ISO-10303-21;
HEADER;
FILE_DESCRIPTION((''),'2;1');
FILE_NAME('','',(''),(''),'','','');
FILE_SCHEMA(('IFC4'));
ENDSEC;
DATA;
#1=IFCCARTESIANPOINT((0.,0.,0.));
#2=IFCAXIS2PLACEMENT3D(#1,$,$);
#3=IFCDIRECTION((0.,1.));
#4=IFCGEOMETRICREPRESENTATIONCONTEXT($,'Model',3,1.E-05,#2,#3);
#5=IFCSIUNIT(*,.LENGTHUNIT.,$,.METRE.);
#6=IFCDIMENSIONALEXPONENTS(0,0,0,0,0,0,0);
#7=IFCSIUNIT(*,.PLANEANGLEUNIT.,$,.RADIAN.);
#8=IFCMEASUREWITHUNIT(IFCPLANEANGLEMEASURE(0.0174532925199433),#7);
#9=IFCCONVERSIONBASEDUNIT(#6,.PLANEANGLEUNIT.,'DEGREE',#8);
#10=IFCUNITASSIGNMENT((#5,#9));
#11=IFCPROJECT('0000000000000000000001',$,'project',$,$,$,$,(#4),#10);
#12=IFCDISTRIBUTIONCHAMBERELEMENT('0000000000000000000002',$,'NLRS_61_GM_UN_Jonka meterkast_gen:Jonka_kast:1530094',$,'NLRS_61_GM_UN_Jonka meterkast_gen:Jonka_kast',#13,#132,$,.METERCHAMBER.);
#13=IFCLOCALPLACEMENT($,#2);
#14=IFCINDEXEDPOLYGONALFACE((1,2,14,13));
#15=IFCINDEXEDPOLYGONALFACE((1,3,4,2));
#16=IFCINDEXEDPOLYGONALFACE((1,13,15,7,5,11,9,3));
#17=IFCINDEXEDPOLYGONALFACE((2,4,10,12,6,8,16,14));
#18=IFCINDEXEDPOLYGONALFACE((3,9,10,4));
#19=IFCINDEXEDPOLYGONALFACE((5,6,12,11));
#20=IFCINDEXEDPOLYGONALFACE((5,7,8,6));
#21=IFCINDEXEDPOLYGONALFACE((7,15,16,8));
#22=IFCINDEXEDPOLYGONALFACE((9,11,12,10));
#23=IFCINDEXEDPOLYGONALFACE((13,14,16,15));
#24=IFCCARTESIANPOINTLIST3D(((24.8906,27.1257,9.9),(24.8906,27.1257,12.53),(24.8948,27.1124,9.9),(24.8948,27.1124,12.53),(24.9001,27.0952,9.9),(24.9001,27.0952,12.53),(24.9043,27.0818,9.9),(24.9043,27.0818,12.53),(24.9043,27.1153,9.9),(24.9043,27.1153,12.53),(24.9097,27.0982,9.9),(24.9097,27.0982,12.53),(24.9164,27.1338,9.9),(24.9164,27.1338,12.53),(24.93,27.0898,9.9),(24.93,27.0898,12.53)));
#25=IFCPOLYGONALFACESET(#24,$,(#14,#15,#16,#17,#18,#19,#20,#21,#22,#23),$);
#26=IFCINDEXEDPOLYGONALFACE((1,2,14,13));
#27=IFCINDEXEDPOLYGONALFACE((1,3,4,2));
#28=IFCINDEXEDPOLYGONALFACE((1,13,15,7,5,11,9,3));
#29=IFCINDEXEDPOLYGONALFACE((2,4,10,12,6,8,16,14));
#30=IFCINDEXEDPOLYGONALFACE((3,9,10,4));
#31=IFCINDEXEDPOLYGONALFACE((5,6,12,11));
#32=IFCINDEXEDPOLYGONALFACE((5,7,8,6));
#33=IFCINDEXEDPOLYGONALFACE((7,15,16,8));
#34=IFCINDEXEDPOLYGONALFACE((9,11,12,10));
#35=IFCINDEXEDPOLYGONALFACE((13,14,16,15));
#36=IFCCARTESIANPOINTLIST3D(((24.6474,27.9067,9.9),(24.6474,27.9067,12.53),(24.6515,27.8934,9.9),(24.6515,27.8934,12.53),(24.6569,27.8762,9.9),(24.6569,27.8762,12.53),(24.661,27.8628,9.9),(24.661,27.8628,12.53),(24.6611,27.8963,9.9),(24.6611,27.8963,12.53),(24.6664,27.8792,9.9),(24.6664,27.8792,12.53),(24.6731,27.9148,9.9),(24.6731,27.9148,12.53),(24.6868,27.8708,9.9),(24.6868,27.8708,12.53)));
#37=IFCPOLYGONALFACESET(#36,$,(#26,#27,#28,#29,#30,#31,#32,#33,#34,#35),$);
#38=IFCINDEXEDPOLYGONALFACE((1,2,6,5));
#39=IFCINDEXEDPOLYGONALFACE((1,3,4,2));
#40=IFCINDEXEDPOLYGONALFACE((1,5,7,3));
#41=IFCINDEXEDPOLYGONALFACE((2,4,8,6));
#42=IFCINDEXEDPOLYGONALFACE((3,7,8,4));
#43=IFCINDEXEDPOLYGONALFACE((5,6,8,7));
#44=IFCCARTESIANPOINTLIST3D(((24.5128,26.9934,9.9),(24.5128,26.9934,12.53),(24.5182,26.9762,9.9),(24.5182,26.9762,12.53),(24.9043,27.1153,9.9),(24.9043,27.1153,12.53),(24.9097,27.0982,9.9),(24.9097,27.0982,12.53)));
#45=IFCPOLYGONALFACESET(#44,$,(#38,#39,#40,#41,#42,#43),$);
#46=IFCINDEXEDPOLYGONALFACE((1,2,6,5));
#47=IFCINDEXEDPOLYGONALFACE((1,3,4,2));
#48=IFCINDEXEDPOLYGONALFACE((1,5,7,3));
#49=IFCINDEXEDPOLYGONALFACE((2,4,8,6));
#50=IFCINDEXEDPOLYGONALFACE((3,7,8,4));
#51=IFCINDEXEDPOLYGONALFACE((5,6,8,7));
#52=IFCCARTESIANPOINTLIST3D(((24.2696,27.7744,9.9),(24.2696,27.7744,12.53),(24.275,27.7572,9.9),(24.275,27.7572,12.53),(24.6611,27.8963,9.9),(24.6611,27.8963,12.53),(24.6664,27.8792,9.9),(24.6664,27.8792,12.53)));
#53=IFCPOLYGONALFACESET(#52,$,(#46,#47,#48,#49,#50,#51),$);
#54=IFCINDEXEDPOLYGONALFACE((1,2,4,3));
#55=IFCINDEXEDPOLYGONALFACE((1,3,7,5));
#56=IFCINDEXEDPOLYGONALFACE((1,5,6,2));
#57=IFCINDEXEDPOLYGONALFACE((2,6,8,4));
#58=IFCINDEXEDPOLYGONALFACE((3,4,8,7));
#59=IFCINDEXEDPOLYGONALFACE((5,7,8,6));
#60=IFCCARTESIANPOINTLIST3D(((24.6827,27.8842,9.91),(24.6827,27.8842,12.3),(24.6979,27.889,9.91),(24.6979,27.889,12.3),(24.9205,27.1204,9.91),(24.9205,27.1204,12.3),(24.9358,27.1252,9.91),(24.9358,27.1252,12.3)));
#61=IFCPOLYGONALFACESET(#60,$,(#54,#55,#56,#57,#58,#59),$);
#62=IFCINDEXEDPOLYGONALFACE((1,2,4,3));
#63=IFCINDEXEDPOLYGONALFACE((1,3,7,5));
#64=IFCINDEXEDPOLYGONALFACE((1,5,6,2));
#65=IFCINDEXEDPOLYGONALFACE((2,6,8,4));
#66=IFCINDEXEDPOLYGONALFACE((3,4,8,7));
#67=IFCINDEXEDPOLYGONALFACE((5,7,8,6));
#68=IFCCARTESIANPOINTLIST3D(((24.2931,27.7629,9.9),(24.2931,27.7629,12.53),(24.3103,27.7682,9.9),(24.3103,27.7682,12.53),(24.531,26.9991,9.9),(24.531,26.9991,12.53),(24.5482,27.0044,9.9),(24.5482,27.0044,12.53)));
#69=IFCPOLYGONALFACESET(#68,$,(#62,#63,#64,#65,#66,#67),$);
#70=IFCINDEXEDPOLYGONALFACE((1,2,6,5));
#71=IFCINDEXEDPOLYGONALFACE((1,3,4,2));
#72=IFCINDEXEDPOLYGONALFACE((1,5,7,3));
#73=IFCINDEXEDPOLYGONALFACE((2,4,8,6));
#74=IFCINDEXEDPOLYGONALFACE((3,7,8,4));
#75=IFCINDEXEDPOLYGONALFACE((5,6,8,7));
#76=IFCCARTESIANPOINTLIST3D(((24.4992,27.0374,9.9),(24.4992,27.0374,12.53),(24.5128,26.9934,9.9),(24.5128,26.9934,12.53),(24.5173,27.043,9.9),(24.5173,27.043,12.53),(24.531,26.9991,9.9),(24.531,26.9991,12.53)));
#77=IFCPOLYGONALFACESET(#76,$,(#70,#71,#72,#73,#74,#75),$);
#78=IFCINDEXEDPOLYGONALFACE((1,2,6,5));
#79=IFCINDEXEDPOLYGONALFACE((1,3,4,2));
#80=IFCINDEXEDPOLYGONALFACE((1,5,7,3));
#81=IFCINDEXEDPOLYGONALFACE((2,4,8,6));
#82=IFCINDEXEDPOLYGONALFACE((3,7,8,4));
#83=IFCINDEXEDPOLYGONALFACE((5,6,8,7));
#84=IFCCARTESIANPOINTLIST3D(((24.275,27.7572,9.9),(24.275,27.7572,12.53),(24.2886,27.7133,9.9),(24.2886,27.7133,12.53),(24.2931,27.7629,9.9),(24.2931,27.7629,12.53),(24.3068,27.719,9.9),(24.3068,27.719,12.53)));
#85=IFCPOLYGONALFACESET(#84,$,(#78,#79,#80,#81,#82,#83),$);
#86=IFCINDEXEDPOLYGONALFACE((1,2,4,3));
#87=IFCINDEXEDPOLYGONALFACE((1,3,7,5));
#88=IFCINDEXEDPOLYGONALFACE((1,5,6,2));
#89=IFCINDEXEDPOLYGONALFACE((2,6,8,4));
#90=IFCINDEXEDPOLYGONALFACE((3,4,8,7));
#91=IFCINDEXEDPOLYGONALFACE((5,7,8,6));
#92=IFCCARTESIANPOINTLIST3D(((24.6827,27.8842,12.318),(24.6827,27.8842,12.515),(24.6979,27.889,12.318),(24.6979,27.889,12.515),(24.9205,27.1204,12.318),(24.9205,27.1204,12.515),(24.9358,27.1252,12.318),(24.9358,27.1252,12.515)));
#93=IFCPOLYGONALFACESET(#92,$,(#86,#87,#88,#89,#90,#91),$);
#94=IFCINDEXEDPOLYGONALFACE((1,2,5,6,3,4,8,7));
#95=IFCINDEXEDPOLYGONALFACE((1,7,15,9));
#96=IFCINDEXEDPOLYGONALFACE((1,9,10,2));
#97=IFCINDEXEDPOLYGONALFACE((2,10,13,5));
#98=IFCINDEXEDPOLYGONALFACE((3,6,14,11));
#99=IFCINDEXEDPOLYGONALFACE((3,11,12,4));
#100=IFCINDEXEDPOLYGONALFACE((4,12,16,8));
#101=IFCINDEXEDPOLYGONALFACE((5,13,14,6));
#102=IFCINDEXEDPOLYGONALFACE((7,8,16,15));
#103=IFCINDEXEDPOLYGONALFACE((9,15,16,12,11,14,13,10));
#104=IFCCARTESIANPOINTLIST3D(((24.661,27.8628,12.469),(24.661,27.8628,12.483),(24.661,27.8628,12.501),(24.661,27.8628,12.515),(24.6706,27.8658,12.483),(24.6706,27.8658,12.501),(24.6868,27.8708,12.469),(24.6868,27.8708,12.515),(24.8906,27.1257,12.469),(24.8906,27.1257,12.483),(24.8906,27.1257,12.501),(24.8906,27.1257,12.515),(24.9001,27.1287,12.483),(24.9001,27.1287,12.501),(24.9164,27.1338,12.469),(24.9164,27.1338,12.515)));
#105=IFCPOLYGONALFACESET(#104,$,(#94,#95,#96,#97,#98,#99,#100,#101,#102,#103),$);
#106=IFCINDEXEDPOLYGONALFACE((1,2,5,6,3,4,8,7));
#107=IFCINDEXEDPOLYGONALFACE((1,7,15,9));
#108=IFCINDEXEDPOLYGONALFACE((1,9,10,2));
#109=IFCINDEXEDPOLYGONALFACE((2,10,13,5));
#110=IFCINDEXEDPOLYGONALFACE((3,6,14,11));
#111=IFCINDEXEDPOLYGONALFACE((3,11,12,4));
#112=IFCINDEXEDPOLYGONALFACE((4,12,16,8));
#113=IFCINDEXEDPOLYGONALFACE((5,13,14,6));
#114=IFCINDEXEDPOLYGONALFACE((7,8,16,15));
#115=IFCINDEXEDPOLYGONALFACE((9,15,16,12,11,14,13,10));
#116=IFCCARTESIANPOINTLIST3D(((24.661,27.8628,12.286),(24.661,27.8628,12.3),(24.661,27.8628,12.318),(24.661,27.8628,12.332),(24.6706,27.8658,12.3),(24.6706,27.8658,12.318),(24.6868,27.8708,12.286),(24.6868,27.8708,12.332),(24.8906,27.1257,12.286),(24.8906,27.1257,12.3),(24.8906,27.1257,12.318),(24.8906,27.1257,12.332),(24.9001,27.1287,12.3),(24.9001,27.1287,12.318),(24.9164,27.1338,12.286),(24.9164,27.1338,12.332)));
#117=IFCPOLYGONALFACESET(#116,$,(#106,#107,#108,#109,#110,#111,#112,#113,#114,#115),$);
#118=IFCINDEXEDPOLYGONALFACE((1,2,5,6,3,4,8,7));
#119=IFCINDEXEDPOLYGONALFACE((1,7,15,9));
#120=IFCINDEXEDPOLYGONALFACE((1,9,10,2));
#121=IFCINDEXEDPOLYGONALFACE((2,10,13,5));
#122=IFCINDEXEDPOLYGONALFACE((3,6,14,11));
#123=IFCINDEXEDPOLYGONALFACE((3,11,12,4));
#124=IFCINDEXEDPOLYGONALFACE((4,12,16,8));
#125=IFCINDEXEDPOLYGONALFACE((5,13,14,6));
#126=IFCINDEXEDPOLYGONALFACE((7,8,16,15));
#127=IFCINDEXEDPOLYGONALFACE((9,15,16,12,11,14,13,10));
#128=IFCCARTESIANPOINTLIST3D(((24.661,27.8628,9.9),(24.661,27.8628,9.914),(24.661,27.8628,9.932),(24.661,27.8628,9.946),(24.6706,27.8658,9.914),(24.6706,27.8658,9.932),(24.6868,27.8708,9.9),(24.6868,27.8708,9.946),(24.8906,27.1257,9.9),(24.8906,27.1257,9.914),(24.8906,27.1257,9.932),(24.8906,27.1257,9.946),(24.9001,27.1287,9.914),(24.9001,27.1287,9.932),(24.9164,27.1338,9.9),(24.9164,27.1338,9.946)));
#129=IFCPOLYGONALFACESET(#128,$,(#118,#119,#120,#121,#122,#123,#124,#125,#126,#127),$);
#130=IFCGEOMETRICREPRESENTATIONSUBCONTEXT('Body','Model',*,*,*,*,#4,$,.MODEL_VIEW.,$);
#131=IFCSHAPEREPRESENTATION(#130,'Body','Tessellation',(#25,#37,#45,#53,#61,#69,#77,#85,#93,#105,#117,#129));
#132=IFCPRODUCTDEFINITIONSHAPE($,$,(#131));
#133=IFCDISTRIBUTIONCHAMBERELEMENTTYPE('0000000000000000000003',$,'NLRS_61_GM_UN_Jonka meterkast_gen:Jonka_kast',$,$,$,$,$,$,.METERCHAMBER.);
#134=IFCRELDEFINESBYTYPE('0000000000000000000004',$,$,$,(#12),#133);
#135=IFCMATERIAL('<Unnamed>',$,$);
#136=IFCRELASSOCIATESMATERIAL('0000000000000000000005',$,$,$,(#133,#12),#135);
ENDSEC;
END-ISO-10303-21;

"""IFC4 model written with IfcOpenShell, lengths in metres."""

from ifc_helpers import new_model, entity, si_unit, converted_unit, direction, frame, origin, place, context, subcontext, project, indexed_curve, outline, extrude, source, transform, mapped, material, type_object, type_shapes, element, save


model = new_model("IFC4")

# Units and contexts
model_context = context("Model", 3, precision=1e-05, world=origin(), true_north=direction((0.0, 1.0)))
body_context = subcontext(model_context, "Body", "Model", "MODEL_VIEW")
ifc_project = project(units=[si_unit("LENGTHUNIT", "METRE"), converted_unit("PLANEANGLEUNIT", "DEGREE", entity("IfcPlaneAngleMeasure", 0.0174532925199433), si_unit("PLANEANGLEUNIT", "RADIAN"), dimensions=[0, 0, 0, 0, 0, 0, 0])], contexts=[model_context])

# Distribution chamber element
ifc_material = material(Name="<Unnamed>")
distribution_chamber_element_type = type_object("IfcDistributionChamberElementType", Name="NLRS_61_GM_UN_Jonka meterkast_gen:Jonka_kast", PredefinedType="METERCHAMBER", material=ifc_material)
shared_shape_1 = source(origin(), body_context, "Body", "SweptSolid", [
    extrude(outline(indexed_curve([(-0.0093, -0.023), (0.0178, -0.023), (0.0178, 0.023), (-0.0093, 0.023), (-0.0093, 0.009), (0.0007, 0.009), (0.0007, -0.009), (-0.0093, -0.009), (-0.0093, -0.023)], self_intersect=False)), frame((-0.409, -0.4092, 0.0), z_axis=(0.0, 0.0, 1.0), x_axis=(0.0, -1.0, 0.0)), (0.0, 0.0, 1.0), 2.63),
    extrude(outline(indexed_curve([(-0.0093, -0.023), (0.0178, -0.023), (0.0178, 0.023), (-0.0093, 0.023), (-0.0093, 0.009), (0.0007, 0.009), (0.0007, -0.009), (-0.0093, -0.009), (-0.0093, -0.023)], self_intersect=False)), frame((0.409, -0.4092, 0.0), z_axis=(0.0, 0.0, 1.0), x_axis=(0.0, -1.0, 0.0)), (0.0, 0.0, 1.0), 2.63),
    extrude(outline(indexed_curve([(-0.205, -0.009), (0.205, -0.009), (0.205, 0.009), (-0.205, 0.009), (-0.205, -0.009)], self_intersect=False)), frame((-0.409, -0.205, 0.0), z_axis=(0.0, 0.0, 1.0), x_axis=(0.0, -1.0, 0.0)), (0.0, 0.0, 1.0), 2.63),
    extrude(outline(indexed_curve([(-0.205, -0.009), (0.205, -0.009), (0.205, 0.009), (-0.205, 0.009), (-0.205, -0.009)], self_intersect=False)), frame((0.409, -0.205, 0.0), z_axis=(0.0, 0.0, 1.0), x_axis=(0.0, -1.0, 0.0)), (0.0, 0.0, 1.0), 2.63),
    extrude(outline(indexed_curve([(-0.4, -0.008), (0.4, -0.008), (0.4, 0.008), (-0.4, 0.008), (-0.4, -0.008)], self_intersect=False)), frame((0.0, -0.435, 0.01), z_axis=(0.0, 0.0, 1.0), x_axis=(-1.0, 0.0, 0.0)), (0.0, 0.0, 1.0), 2.39),
    extrude(outline(indexed_curve([(-0.4, -0.009), (0.4, -0.009), (0.4, 0.009), (-0.4, 0.009), (-0.4, -0.009)], self_intersect=False)), frame((0.0, -0.028, 0.0), z_axis=(0.0, 0.0, 1.0), x_axis=(-1.0, 0.0, 0.0)), (0.0, 0.0, 1.0), 2.63),
    extrude(outline(indexed_curve([(-0.023, -0.0095), (0.023, -0.0095), (0.023, 0.0095), (-0.023, 0.0095), (-0.023, -0.0095)], self_intersect=False)), frame((-0.377, -0.0095, 0.0), z_axis=(0.0, 0.0, 1.0), x_axis=(-1.0, 0.0, 0.0)), (0.0, 0.0, 1.0), 2.63),
    extrude(outline(indexed_curve([(-0.023, -0.0095), (0.023, -0.0095), (0.023, 0.0095), (-0.023, 0.0095), (-0.023, -0.0095)], self_intersect=False)), frame((0.377, -0.0095, 0.0), z_axis=(0.0, 0.0, 1.0), x_axis=(-1.0, 0.0, 0.0)), (0.0, 0.0, 1.0), 2.63),
    extrude(outline(indexed_curve([(-0.4, -0.008), (0.4, -0.008), (0.4, 0.008), (-0.4, 0.008), (-0.4, -0.008)], self_intersect=False)), frame((0.0, -0.435, 2.418), z_axis=(0.0, 0.0, 1.0), x_axis=(-1.0, 0.0, 0.0)), (0.0, 0.0, 1.0), 0.197),
    extrude(outline(indexed_curve([(-0.023, -0.0178), (0.023, -0.0178), (0.023, 0.0093), (0.009, 0.0093), (0.009, -0.0007), (-0.009, -0.0007), (-0.009, 0.0093), (-0.023, 0.0093), (-0.023, -0.0178)], self_intersect=False)), frame((-0.386, -0.4092, 2.592), z_axis=(1.0, 0.0, 0.0), x_axis=(0.0, 0.0, -1.0)), (0.0, 0.0, 1.0), 0.772),
    extrude(outline(indexed_curve([(-0.023, -0.0178), (0.023, -0.0178), (0.023, 0.0093), (0.009, 0.0093), (0.009, -0.0007), (-0.009, -0.0007), (-0.009, 0.0093), (-0.023, 0.0093), (-0.023, -0.0178)], self_intersect=False)), frame((-0.386, -0.4092, 2.409), z_axis=(1.0, 0.0, 0.0), x_axis=(0.0, 0.0, -1.0)), (0.0, 0.0, 1.0), 0.772),
    extrude(outline(indexed_curve([(-0.023, -0.0178), (0.023, -0.0178), (0.023, 0.0093), (0.009, 0.0093), (0.009, -0.0007), (-0.009, -0.0007), (-0.009, 0.0093), (-0.023, 0.0093), (-0.023, -0.0178)], self_intersect=False)), frame((-0.386, -0.4092, 0.023), z_axis=(1.0, 0.0, 0.0), x_axis=(0.0, 0.0, -1.0)), (0.0, 0.0, 1.0), 0.772),
])
type_shapes(distribution_chamber_element_type, [shared_shape_1])
placement_1 = place(None, frame((13.1348, 11.9886, 0.0), z_axis=(0.0, 0.0, 1.0), x_axis=(0.954771, 0.297342, 0.0)))
placement_2 = place(placement_1, origin())
placement_3 = place(placement_2, frame((0.0, 0.0, 9.9)))
placement_4 = place(placement_3, origin())
distribution_chamber_element_1_placement = place(placement_4, frame((15.325, 11.343, 0.0), z_axis=(0.0, 0.0, 1.0), x_axis=(0.0, 1.0, 0.0)))
element("IfcDistributionChamberElement", 1, at=distribution_chamber_element_1_placement, type_object=distribution_chamber_element_type, material=ifc_material, Name="NLRS_61_GM_UN_Jonka meterkast_gen:Jonka_kast:1530094", ObjectType="NLRS_61_GM_UN_Jonka meterkast_gen:Jonka_kast", PredefinedType="METERCHAMBER", context=body_context, shape_type="MappedRepresentation", body=[
    mapped(shared_shape_1, transform((0.0, 0.0, 0.0), scale=1.0)),
])

save(model, "model.ifc")
